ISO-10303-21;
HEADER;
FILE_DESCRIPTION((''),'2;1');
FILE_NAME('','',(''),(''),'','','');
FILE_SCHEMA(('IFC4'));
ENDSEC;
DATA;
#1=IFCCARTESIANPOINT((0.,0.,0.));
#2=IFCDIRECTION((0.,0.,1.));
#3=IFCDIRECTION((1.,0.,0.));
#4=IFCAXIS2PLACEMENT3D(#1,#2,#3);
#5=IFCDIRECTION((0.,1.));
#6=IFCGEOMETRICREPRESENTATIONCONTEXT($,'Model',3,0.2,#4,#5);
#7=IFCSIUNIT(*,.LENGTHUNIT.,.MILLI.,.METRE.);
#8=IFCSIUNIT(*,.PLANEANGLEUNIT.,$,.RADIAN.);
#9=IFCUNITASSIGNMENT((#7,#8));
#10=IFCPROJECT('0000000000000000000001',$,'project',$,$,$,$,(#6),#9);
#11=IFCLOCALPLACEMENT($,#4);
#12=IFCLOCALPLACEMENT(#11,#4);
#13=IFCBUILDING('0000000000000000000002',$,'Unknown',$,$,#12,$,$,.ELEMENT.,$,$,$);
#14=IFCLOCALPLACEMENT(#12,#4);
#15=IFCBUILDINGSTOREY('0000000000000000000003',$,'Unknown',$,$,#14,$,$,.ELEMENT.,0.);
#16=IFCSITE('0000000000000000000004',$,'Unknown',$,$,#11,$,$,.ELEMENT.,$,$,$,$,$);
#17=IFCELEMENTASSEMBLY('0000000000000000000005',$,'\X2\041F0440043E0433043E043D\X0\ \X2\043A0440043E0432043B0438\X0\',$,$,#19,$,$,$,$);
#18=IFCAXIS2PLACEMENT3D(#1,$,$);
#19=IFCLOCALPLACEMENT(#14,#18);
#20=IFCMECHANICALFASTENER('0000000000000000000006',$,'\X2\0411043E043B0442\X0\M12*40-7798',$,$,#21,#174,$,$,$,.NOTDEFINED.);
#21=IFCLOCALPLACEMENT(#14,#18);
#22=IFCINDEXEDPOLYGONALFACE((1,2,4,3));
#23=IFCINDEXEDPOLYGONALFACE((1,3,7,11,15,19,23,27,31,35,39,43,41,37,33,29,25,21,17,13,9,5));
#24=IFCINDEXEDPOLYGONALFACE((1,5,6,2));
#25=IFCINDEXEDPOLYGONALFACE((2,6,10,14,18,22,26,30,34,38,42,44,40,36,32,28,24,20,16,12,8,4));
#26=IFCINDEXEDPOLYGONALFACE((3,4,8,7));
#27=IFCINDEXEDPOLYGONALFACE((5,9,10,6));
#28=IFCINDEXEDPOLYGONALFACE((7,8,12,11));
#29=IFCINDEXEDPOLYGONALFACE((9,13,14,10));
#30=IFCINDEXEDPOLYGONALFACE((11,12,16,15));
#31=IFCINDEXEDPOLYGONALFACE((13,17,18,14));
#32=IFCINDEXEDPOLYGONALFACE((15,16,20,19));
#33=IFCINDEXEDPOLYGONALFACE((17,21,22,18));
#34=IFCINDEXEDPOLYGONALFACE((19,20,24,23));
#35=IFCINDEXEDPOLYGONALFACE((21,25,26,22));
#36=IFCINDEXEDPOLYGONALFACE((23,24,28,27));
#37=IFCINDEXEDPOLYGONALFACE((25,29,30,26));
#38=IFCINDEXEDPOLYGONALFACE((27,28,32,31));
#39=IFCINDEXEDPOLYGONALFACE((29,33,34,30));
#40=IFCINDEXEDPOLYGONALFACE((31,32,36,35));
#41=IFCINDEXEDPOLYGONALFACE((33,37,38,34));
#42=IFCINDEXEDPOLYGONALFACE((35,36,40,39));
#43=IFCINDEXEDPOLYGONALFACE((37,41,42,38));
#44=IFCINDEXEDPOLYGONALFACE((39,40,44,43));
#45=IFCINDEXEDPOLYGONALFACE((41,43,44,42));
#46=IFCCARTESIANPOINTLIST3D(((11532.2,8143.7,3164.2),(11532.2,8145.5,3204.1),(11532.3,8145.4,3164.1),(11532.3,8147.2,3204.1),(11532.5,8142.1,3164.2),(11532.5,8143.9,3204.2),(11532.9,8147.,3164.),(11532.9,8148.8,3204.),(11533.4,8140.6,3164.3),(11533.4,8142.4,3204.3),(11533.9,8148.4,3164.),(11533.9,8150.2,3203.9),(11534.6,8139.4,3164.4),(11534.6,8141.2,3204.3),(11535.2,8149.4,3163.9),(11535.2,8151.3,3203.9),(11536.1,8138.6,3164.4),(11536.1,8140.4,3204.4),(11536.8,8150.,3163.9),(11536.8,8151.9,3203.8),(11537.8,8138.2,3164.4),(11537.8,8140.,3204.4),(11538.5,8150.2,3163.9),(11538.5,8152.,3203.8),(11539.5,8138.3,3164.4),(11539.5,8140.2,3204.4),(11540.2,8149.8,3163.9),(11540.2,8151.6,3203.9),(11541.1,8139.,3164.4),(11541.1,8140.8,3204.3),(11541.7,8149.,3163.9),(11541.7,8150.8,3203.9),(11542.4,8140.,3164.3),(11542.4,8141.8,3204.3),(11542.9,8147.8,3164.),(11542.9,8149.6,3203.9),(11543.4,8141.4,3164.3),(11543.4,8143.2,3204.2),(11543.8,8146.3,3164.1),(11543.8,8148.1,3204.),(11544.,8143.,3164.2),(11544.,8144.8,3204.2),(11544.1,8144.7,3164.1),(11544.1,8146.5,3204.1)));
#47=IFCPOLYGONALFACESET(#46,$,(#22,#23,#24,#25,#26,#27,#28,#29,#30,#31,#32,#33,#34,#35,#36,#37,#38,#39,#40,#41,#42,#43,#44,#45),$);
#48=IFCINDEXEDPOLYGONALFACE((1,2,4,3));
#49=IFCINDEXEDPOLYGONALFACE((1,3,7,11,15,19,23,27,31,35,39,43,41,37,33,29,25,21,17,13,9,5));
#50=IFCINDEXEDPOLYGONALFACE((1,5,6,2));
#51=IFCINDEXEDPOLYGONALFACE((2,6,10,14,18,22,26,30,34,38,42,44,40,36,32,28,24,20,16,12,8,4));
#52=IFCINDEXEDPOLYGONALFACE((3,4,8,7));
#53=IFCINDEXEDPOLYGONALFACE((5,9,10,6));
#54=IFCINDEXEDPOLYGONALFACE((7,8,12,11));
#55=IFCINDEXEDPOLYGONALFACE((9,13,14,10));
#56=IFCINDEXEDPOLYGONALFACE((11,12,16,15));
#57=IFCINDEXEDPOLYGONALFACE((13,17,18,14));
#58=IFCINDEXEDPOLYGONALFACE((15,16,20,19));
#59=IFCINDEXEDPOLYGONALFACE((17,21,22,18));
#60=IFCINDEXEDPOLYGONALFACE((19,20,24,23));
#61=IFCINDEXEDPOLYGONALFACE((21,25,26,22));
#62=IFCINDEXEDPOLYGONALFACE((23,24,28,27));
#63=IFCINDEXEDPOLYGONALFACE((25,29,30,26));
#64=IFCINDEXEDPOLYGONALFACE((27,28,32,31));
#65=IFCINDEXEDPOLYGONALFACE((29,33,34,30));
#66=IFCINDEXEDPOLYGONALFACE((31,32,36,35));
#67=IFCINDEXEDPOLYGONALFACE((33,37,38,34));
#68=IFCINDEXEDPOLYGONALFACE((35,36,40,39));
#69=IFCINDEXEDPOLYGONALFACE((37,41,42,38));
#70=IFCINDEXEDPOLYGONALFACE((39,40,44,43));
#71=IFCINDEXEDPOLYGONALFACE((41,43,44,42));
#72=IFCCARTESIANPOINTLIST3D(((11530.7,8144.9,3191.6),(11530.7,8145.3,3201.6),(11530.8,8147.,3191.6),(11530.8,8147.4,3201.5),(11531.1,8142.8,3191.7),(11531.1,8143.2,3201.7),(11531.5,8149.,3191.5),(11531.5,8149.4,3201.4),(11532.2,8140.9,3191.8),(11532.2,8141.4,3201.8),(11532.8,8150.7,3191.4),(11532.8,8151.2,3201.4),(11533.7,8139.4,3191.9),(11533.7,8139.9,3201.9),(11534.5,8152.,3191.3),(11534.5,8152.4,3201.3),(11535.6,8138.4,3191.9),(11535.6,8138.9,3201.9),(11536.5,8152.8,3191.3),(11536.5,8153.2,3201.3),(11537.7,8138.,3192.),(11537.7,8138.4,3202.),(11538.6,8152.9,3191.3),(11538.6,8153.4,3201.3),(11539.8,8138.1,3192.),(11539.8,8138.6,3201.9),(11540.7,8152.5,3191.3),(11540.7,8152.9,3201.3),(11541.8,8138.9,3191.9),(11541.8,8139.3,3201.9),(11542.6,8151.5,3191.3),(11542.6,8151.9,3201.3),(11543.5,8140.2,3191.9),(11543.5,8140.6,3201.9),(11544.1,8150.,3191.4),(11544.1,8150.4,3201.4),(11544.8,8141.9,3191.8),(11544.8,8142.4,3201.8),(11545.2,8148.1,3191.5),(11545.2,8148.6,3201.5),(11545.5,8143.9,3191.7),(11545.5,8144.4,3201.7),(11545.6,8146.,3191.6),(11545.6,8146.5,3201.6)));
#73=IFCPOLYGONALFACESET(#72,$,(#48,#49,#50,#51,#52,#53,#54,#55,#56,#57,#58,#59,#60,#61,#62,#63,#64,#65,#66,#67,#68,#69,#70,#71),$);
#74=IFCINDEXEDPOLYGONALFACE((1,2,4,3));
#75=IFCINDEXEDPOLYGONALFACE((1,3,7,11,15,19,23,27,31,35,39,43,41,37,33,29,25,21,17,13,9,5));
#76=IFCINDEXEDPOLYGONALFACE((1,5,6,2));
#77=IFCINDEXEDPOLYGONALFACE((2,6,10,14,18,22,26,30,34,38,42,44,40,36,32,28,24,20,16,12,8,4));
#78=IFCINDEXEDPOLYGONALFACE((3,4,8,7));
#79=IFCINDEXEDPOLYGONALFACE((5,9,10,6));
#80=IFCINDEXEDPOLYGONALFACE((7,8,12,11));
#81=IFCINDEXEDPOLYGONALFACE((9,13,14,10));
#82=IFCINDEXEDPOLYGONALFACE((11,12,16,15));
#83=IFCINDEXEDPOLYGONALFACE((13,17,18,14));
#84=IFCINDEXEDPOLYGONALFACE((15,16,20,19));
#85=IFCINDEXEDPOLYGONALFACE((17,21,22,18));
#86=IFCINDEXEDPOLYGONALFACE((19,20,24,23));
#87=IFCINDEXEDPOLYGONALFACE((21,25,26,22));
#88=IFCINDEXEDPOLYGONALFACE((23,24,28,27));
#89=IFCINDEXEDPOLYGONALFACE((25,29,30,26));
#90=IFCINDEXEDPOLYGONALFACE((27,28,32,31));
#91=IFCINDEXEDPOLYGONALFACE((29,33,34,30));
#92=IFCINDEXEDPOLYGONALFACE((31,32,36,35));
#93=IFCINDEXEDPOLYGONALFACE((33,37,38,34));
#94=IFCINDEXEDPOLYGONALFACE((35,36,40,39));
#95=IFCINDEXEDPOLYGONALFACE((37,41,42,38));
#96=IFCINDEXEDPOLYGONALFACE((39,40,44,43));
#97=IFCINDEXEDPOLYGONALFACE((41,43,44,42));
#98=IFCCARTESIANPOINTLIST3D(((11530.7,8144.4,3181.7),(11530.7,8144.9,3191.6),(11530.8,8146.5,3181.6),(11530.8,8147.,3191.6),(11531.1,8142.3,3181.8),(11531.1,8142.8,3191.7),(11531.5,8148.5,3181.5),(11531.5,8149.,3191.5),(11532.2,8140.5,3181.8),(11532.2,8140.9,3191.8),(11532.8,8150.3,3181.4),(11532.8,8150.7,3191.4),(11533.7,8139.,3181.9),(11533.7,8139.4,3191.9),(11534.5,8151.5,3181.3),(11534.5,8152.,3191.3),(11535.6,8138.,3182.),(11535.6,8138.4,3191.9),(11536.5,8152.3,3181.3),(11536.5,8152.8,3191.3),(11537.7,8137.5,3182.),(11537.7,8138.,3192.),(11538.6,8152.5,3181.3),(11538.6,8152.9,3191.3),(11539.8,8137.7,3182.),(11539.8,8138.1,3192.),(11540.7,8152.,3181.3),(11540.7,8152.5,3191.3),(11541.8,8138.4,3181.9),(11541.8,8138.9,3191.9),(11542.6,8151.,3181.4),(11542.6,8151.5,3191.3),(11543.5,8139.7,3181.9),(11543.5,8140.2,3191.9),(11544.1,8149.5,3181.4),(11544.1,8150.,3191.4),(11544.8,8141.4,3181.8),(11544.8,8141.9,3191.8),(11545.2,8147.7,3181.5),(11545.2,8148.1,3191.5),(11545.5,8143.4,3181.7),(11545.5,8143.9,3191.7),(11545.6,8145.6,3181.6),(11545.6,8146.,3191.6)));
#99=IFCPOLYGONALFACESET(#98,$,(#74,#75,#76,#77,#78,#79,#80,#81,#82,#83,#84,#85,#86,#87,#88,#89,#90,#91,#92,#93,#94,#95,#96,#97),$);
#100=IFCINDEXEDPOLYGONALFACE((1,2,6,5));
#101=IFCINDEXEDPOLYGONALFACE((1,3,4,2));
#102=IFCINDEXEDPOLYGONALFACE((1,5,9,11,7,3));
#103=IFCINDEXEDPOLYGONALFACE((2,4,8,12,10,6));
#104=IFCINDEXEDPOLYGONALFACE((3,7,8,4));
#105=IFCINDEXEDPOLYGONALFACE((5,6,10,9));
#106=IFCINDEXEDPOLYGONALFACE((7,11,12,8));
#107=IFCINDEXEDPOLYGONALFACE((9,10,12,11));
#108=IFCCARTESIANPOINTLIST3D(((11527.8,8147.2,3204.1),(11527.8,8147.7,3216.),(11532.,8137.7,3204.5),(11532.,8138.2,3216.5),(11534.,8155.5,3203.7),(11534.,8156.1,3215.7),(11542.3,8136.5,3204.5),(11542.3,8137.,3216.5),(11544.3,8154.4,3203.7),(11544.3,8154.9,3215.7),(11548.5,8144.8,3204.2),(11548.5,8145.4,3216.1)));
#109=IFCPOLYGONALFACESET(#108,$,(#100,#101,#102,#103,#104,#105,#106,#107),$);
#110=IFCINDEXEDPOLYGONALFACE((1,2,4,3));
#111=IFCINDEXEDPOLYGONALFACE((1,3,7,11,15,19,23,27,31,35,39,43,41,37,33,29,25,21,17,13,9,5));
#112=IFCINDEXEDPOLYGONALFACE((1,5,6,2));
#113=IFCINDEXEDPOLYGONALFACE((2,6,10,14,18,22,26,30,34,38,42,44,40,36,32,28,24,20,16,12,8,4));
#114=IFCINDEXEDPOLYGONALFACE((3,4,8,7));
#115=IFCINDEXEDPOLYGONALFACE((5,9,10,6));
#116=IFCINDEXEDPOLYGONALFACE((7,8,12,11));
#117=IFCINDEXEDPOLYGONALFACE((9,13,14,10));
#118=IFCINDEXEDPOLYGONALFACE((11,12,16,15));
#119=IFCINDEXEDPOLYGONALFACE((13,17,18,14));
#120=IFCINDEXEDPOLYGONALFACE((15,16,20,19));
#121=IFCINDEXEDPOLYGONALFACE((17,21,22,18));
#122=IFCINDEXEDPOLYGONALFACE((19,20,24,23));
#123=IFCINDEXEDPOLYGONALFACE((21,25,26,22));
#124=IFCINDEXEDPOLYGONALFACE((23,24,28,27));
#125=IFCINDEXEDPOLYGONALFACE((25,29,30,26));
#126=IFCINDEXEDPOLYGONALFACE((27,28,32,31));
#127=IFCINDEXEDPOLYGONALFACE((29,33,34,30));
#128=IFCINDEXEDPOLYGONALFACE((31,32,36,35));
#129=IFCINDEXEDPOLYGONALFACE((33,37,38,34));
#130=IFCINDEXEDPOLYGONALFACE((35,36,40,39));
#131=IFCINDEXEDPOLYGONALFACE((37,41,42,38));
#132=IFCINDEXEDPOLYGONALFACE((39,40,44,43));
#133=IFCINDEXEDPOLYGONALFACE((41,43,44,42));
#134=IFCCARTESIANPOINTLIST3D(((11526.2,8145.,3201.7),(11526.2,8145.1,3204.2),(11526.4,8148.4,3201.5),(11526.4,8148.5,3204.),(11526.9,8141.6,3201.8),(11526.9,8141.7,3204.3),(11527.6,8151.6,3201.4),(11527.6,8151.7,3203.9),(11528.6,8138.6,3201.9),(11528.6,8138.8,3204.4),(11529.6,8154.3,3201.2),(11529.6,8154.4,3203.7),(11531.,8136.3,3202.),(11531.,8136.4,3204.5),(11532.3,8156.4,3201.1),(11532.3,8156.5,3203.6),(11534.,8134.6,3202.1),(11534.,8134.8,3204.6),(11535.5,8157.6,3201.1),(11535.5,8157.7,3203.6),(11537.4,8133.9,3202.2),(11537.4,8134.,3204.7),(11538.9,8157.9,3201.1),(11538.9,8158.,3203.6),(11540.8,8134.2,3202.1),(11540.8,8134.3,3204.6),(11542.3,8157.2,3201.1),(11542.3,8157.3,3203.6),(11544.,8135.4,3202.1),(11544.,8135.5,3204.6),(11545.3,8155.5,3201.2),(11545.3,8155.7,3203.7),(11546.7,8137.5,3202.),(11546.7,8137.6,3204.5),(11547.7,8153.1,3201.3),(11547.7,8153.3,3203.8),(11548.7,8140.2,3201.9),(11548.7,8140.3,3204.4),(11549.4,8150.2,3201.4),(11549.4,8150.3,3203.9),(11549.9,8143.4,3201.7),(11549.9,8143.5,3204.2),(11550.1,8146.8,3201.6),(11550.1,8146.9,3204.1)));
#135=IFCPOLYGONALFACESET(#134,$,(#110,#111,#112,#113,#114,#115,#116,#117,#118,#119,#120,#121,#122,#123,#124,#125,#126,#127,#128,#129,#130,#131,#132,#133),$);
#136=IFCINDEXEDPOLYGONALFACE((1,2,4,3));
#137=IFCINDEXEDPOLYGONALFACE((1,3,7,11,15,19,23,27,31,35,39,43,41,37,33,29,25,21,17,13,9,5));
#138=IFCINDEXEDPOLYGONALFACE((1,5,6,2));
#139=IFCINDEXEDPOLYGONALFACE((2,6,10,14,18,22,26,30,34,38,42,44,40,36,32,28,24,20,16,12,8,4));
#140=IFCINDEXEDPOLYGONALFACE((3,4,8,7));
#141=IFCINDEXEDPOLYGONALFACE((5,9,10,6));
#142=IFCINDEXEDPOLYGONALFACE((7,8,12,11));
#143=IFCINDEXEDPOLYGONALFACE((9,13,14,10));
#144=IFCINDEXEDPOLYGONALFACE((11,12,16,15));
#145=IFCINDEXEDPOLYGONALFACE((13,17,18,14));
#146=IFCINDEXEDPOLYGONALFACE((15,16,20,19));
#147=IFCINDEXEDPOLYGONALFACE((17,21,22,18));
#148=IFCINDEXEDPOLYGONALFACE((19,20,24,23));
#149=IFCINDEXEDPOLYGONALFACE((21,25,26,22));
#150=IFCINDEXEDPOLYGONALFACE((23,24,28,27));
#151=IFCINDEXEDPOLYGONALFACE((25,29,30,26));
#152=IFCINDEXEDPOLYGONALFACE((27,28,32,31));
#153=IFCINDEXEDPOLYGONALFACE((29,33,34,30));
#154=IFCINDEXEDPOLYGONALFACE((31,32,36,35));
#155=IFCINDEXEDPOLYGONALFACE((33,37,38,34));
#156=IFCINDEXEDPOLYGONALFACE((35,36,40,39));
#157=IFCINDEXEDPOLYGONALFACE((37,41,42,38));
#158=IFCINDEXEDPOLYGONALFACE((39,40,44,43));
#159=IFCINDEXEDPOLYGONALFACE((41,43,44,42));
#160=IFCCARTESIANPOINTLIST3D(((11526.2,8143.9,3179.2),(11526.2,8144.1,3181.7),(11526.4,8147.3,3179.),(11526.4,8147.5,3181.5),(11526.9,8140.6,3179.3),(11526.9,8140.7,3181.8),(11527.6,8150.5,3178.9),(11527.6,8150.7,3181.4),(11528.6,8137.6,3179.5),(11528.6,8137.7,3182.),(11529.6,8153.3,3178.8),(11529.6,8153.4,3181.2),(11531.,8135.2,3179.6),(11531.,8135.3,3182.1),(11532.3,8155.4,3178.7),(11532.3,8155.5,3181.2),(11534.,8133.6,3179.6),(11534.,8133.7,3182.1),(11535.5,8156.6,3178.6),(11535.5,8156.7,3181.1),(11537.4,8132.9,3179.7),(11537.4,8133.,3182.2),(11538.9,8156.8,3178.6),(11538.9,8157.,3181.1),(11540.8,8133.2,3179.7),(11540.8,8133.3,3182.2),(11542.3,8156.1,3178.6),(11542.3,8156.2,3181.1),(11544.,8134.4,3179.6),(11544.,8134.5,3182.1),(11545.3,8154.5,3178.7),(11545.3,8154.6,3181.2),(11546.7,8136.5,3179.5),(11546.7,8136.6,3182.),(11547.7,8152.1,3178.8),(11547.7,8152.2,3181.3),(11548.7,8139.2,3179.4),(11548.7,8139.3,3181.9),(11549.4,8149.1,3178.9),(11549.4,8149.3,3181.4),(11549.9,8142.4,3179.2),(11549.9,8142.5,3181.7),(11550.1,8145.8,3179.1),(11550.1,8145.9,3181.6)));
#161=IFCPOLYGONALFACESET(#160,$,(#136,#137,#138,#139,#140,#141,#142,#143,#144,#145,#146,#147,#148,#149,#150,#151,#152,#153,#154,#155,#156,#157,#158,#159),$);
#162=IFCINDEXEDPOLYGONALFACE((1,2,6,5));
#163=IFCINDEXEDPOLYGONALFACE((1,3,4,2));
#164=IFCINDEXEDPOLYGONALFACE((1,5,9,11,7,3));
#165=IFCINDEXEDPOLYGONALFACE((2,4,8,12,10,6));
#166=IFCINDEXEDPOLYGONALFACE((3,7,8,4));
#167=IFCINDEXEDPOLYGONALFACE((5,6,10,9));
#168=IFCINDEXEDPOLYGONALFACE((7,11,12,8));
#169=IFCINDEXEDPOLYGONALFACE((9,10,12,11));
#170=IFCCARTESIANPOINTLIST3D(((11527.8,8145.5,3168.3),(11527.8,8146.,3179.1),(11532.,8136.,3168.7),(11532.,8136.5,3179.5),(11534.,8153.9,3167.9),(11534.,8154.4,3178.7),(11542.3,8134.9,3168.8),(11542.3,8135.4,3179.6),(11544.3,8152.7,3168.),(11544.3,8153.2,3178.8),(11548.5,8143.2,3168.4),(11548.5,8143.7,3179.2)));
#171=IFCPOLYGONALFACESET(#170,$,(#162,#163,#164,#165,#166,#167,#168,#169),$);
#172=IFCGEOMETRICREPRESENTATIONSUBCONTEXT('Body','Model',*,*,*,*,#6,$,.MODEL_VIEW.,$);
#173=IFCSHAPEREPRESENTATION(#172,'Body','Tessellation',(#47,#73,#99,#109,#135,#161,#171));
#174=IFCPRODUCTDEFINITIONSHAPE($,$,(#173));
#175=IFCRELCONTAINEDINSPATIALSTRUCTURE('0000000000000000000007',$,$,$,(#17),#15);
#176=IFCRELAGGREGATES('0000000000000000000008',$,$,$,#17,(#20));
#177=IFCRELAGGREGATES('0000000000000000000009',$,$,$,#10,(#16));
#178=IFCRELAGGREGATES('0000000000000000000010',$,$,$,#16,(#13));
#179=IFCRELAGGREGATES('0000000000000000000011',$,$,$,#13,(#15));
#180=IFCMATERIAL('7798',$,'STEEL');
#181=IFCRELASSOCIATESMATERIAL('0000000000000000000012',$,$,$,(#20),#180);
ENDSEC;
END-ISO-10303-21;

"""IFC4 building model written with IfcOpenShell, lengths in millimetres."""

from ifc_helpers import new_model, si_unit, direction, frame, origin_with_axes, place, context, subcontext, project, spatial, line, arc, indexed_curve, outline, extrude, source, transform, mapped, material, element, aggregate, save


model = new_model("IFC4")

# Units and contexts
model_context = context("Model", 3, precision=0.2, world=origin_with_axes(), true_north=direction((0.0, 1.0)))
body_context = subcontext(model_context, "Body", "Model", "MODEL_VIEW")
ifc_project = project(units=[si_unit("LENGTHUNIT", "METRE", prefix="MILLI"), si_unit("PLANEANGLEUNIT", "RADIAN")], contexts=[model_context])

# Site, building, storey
site_placement = place(None, origin_with_axes())
site = spatial("IfcSite", under=ifc_project, at=site_placement, Name="Unknown", CompositionType="ELEMENT")
building_placement = place(site_placement, origin_with_axes())
building = spatial("IfcBuilding", under=site, at=building_placement, Name="Unknown", CompositionType="ELEMENT")
storey_placement = place(building_placement, origin_with_axes())
storey = spatial("IfcBuildingStorey", under=building, at=storey_placement, Name="Unknown", CompositionType="ELEMENT", Elevation=0.0)

# Element assembly
assembly_1_placement = place(storey_placement, frame((17395.0, 8247.1, 3182.0), z_axis=(0.0, 0.998969, -0.045408), x_axis=(-1.0, 0.0, 0.0)))
assembly_1 = element("IfcElementAssembly", 1, at=assembly_1_placement, inside=storey, Name="Прогон кровли")

# Mechanical fastener
ifc_material_1 = material(Name="7798", Category="STEEL")
shared_shape_1 = source(origin_with_axes(), body_context, "Body", "SweptSolid", [
    extrude(outline(indexed_curve([(6.0, 0.0), (0.0, 6.0), (-6.0, 0.0), (0.0, -6.0)], segments=[arc(1, 2, 3), arc(3, 4, 1)])), frame((0.0, 0.0, 12.5), z_axis=(0.0, 0.0, -1.0), x_axis=(0.0, 1.0, 0.0)), (0.0, 0.0, 1.0), 40.0),
    extrude(outline(indexed_curve([(7.5, 0.0), (0.0, 7.5), (-7.5, 0.0), (0.0, -7.5)], segments=[arc(1, 2, 3), arc(3, 4, 1)])), frame((0.0, 0.0, 10.0), z_axis=(0.0, 0.0, -1.0), x_axis=(0.0, 1.0, 0.0)), (0.0, 0.0, 1.0), 10.0),
    extrude(outline(indexed_curve([(7.5, 0.0), (0.0, 7.5), (-7.5, 0.0), (0.0, -7.5)], segments=[arc(1, 2, 3), arc(3, 4, 1)])), frame((0.0, 0.0, 0.0), z_axis=(0.0, 0.0, -1.0), x_axis=(0.0, 1.0, 0.0)), (0.0, 0.0, 1.0), 10.0),
    extrude(outline(indexed_curve([(10.4, 0.0), (5.2, 9.0), (-5.2, 9.0), (-10.4, 0.0), (-5.2, -9.0), (5.2, -9.0)], segments=[line(1, 2, 3, 4, 5, 6, 1)])), frame((0.0, 0.0, 24.5), z_axis=(0.0, 0.0, -1.0), x_axis=(0.0, 1.0, 0.0)), (0.0, 0.0, 1.0), 12.0),
    extrude(outline(indexed_curve([(12.0, 0.0), (0.0, 12.0), (-12.0, 0.0), (0.0, -12.0)], segments=[arc(1, 2, 3), arc(3, 4, 1)])), frame((0.0, 0.0, 12.5), z_axis=(0.0, 0.0, -1.0), x_axis=(0.0, 1.0, 0.0)), (0.0, 0.0, 1.0), 2.5),
    extrude(outline(indexed_curve([(12.0, 0.0), (0.0, 12.0), (-12.0, 0.0), (0.0, -12.0)], segments=[arc(1, 2, 3), arc(3, 4, 1)])), frame((0.0, 0.0, -10.0), z_axis=(0.0, 0.0, -1.0), x_axis=(0.0, 1.0, 0.0)), (0.0, 0.0, 1.0), 2.5),
    extrude(outline(indexed_curve([(10.4, 0.0), (5.2, 9.0), (-5.2, 9.0), (-10.4, 0.0), (-5.2, -9.0), (5.2, -9.0)], segments=[line(1, 2, 3, 4, 5, 6, 1)])), frame((0.0, 0.0, -12.5), z_axis=(0.0, 0.0, -1.0), x_axis=(0.0, 1.0, 0.0)), (0.0, 0.0, 1.0), 10.8),
])
mechanical_fastener_1_placement = place(assembly_1_placement, frame((5856.9, 5.0, -102.0), z_axis=(0.0, 1.0, 0.0), x_axis=(-0.804616, 0.0, -0.593795)))
mechanical_fastener_1 = element("IfcMechanicalFastener", 2, at=mechanical_fastener_1_placement, material=ifc_material_1, Name="БолтM12*40-7798", PredefinedType="NOTDEFINED", context=body_context, shape_type="MappedRepresentation", body=[
    mapped(shared_shape_1, transform((0.0, 0.0, 0.0))),
])
aggregate(assembly_1, [mechanical_fastener_1])

save(model, "model.ifc")
